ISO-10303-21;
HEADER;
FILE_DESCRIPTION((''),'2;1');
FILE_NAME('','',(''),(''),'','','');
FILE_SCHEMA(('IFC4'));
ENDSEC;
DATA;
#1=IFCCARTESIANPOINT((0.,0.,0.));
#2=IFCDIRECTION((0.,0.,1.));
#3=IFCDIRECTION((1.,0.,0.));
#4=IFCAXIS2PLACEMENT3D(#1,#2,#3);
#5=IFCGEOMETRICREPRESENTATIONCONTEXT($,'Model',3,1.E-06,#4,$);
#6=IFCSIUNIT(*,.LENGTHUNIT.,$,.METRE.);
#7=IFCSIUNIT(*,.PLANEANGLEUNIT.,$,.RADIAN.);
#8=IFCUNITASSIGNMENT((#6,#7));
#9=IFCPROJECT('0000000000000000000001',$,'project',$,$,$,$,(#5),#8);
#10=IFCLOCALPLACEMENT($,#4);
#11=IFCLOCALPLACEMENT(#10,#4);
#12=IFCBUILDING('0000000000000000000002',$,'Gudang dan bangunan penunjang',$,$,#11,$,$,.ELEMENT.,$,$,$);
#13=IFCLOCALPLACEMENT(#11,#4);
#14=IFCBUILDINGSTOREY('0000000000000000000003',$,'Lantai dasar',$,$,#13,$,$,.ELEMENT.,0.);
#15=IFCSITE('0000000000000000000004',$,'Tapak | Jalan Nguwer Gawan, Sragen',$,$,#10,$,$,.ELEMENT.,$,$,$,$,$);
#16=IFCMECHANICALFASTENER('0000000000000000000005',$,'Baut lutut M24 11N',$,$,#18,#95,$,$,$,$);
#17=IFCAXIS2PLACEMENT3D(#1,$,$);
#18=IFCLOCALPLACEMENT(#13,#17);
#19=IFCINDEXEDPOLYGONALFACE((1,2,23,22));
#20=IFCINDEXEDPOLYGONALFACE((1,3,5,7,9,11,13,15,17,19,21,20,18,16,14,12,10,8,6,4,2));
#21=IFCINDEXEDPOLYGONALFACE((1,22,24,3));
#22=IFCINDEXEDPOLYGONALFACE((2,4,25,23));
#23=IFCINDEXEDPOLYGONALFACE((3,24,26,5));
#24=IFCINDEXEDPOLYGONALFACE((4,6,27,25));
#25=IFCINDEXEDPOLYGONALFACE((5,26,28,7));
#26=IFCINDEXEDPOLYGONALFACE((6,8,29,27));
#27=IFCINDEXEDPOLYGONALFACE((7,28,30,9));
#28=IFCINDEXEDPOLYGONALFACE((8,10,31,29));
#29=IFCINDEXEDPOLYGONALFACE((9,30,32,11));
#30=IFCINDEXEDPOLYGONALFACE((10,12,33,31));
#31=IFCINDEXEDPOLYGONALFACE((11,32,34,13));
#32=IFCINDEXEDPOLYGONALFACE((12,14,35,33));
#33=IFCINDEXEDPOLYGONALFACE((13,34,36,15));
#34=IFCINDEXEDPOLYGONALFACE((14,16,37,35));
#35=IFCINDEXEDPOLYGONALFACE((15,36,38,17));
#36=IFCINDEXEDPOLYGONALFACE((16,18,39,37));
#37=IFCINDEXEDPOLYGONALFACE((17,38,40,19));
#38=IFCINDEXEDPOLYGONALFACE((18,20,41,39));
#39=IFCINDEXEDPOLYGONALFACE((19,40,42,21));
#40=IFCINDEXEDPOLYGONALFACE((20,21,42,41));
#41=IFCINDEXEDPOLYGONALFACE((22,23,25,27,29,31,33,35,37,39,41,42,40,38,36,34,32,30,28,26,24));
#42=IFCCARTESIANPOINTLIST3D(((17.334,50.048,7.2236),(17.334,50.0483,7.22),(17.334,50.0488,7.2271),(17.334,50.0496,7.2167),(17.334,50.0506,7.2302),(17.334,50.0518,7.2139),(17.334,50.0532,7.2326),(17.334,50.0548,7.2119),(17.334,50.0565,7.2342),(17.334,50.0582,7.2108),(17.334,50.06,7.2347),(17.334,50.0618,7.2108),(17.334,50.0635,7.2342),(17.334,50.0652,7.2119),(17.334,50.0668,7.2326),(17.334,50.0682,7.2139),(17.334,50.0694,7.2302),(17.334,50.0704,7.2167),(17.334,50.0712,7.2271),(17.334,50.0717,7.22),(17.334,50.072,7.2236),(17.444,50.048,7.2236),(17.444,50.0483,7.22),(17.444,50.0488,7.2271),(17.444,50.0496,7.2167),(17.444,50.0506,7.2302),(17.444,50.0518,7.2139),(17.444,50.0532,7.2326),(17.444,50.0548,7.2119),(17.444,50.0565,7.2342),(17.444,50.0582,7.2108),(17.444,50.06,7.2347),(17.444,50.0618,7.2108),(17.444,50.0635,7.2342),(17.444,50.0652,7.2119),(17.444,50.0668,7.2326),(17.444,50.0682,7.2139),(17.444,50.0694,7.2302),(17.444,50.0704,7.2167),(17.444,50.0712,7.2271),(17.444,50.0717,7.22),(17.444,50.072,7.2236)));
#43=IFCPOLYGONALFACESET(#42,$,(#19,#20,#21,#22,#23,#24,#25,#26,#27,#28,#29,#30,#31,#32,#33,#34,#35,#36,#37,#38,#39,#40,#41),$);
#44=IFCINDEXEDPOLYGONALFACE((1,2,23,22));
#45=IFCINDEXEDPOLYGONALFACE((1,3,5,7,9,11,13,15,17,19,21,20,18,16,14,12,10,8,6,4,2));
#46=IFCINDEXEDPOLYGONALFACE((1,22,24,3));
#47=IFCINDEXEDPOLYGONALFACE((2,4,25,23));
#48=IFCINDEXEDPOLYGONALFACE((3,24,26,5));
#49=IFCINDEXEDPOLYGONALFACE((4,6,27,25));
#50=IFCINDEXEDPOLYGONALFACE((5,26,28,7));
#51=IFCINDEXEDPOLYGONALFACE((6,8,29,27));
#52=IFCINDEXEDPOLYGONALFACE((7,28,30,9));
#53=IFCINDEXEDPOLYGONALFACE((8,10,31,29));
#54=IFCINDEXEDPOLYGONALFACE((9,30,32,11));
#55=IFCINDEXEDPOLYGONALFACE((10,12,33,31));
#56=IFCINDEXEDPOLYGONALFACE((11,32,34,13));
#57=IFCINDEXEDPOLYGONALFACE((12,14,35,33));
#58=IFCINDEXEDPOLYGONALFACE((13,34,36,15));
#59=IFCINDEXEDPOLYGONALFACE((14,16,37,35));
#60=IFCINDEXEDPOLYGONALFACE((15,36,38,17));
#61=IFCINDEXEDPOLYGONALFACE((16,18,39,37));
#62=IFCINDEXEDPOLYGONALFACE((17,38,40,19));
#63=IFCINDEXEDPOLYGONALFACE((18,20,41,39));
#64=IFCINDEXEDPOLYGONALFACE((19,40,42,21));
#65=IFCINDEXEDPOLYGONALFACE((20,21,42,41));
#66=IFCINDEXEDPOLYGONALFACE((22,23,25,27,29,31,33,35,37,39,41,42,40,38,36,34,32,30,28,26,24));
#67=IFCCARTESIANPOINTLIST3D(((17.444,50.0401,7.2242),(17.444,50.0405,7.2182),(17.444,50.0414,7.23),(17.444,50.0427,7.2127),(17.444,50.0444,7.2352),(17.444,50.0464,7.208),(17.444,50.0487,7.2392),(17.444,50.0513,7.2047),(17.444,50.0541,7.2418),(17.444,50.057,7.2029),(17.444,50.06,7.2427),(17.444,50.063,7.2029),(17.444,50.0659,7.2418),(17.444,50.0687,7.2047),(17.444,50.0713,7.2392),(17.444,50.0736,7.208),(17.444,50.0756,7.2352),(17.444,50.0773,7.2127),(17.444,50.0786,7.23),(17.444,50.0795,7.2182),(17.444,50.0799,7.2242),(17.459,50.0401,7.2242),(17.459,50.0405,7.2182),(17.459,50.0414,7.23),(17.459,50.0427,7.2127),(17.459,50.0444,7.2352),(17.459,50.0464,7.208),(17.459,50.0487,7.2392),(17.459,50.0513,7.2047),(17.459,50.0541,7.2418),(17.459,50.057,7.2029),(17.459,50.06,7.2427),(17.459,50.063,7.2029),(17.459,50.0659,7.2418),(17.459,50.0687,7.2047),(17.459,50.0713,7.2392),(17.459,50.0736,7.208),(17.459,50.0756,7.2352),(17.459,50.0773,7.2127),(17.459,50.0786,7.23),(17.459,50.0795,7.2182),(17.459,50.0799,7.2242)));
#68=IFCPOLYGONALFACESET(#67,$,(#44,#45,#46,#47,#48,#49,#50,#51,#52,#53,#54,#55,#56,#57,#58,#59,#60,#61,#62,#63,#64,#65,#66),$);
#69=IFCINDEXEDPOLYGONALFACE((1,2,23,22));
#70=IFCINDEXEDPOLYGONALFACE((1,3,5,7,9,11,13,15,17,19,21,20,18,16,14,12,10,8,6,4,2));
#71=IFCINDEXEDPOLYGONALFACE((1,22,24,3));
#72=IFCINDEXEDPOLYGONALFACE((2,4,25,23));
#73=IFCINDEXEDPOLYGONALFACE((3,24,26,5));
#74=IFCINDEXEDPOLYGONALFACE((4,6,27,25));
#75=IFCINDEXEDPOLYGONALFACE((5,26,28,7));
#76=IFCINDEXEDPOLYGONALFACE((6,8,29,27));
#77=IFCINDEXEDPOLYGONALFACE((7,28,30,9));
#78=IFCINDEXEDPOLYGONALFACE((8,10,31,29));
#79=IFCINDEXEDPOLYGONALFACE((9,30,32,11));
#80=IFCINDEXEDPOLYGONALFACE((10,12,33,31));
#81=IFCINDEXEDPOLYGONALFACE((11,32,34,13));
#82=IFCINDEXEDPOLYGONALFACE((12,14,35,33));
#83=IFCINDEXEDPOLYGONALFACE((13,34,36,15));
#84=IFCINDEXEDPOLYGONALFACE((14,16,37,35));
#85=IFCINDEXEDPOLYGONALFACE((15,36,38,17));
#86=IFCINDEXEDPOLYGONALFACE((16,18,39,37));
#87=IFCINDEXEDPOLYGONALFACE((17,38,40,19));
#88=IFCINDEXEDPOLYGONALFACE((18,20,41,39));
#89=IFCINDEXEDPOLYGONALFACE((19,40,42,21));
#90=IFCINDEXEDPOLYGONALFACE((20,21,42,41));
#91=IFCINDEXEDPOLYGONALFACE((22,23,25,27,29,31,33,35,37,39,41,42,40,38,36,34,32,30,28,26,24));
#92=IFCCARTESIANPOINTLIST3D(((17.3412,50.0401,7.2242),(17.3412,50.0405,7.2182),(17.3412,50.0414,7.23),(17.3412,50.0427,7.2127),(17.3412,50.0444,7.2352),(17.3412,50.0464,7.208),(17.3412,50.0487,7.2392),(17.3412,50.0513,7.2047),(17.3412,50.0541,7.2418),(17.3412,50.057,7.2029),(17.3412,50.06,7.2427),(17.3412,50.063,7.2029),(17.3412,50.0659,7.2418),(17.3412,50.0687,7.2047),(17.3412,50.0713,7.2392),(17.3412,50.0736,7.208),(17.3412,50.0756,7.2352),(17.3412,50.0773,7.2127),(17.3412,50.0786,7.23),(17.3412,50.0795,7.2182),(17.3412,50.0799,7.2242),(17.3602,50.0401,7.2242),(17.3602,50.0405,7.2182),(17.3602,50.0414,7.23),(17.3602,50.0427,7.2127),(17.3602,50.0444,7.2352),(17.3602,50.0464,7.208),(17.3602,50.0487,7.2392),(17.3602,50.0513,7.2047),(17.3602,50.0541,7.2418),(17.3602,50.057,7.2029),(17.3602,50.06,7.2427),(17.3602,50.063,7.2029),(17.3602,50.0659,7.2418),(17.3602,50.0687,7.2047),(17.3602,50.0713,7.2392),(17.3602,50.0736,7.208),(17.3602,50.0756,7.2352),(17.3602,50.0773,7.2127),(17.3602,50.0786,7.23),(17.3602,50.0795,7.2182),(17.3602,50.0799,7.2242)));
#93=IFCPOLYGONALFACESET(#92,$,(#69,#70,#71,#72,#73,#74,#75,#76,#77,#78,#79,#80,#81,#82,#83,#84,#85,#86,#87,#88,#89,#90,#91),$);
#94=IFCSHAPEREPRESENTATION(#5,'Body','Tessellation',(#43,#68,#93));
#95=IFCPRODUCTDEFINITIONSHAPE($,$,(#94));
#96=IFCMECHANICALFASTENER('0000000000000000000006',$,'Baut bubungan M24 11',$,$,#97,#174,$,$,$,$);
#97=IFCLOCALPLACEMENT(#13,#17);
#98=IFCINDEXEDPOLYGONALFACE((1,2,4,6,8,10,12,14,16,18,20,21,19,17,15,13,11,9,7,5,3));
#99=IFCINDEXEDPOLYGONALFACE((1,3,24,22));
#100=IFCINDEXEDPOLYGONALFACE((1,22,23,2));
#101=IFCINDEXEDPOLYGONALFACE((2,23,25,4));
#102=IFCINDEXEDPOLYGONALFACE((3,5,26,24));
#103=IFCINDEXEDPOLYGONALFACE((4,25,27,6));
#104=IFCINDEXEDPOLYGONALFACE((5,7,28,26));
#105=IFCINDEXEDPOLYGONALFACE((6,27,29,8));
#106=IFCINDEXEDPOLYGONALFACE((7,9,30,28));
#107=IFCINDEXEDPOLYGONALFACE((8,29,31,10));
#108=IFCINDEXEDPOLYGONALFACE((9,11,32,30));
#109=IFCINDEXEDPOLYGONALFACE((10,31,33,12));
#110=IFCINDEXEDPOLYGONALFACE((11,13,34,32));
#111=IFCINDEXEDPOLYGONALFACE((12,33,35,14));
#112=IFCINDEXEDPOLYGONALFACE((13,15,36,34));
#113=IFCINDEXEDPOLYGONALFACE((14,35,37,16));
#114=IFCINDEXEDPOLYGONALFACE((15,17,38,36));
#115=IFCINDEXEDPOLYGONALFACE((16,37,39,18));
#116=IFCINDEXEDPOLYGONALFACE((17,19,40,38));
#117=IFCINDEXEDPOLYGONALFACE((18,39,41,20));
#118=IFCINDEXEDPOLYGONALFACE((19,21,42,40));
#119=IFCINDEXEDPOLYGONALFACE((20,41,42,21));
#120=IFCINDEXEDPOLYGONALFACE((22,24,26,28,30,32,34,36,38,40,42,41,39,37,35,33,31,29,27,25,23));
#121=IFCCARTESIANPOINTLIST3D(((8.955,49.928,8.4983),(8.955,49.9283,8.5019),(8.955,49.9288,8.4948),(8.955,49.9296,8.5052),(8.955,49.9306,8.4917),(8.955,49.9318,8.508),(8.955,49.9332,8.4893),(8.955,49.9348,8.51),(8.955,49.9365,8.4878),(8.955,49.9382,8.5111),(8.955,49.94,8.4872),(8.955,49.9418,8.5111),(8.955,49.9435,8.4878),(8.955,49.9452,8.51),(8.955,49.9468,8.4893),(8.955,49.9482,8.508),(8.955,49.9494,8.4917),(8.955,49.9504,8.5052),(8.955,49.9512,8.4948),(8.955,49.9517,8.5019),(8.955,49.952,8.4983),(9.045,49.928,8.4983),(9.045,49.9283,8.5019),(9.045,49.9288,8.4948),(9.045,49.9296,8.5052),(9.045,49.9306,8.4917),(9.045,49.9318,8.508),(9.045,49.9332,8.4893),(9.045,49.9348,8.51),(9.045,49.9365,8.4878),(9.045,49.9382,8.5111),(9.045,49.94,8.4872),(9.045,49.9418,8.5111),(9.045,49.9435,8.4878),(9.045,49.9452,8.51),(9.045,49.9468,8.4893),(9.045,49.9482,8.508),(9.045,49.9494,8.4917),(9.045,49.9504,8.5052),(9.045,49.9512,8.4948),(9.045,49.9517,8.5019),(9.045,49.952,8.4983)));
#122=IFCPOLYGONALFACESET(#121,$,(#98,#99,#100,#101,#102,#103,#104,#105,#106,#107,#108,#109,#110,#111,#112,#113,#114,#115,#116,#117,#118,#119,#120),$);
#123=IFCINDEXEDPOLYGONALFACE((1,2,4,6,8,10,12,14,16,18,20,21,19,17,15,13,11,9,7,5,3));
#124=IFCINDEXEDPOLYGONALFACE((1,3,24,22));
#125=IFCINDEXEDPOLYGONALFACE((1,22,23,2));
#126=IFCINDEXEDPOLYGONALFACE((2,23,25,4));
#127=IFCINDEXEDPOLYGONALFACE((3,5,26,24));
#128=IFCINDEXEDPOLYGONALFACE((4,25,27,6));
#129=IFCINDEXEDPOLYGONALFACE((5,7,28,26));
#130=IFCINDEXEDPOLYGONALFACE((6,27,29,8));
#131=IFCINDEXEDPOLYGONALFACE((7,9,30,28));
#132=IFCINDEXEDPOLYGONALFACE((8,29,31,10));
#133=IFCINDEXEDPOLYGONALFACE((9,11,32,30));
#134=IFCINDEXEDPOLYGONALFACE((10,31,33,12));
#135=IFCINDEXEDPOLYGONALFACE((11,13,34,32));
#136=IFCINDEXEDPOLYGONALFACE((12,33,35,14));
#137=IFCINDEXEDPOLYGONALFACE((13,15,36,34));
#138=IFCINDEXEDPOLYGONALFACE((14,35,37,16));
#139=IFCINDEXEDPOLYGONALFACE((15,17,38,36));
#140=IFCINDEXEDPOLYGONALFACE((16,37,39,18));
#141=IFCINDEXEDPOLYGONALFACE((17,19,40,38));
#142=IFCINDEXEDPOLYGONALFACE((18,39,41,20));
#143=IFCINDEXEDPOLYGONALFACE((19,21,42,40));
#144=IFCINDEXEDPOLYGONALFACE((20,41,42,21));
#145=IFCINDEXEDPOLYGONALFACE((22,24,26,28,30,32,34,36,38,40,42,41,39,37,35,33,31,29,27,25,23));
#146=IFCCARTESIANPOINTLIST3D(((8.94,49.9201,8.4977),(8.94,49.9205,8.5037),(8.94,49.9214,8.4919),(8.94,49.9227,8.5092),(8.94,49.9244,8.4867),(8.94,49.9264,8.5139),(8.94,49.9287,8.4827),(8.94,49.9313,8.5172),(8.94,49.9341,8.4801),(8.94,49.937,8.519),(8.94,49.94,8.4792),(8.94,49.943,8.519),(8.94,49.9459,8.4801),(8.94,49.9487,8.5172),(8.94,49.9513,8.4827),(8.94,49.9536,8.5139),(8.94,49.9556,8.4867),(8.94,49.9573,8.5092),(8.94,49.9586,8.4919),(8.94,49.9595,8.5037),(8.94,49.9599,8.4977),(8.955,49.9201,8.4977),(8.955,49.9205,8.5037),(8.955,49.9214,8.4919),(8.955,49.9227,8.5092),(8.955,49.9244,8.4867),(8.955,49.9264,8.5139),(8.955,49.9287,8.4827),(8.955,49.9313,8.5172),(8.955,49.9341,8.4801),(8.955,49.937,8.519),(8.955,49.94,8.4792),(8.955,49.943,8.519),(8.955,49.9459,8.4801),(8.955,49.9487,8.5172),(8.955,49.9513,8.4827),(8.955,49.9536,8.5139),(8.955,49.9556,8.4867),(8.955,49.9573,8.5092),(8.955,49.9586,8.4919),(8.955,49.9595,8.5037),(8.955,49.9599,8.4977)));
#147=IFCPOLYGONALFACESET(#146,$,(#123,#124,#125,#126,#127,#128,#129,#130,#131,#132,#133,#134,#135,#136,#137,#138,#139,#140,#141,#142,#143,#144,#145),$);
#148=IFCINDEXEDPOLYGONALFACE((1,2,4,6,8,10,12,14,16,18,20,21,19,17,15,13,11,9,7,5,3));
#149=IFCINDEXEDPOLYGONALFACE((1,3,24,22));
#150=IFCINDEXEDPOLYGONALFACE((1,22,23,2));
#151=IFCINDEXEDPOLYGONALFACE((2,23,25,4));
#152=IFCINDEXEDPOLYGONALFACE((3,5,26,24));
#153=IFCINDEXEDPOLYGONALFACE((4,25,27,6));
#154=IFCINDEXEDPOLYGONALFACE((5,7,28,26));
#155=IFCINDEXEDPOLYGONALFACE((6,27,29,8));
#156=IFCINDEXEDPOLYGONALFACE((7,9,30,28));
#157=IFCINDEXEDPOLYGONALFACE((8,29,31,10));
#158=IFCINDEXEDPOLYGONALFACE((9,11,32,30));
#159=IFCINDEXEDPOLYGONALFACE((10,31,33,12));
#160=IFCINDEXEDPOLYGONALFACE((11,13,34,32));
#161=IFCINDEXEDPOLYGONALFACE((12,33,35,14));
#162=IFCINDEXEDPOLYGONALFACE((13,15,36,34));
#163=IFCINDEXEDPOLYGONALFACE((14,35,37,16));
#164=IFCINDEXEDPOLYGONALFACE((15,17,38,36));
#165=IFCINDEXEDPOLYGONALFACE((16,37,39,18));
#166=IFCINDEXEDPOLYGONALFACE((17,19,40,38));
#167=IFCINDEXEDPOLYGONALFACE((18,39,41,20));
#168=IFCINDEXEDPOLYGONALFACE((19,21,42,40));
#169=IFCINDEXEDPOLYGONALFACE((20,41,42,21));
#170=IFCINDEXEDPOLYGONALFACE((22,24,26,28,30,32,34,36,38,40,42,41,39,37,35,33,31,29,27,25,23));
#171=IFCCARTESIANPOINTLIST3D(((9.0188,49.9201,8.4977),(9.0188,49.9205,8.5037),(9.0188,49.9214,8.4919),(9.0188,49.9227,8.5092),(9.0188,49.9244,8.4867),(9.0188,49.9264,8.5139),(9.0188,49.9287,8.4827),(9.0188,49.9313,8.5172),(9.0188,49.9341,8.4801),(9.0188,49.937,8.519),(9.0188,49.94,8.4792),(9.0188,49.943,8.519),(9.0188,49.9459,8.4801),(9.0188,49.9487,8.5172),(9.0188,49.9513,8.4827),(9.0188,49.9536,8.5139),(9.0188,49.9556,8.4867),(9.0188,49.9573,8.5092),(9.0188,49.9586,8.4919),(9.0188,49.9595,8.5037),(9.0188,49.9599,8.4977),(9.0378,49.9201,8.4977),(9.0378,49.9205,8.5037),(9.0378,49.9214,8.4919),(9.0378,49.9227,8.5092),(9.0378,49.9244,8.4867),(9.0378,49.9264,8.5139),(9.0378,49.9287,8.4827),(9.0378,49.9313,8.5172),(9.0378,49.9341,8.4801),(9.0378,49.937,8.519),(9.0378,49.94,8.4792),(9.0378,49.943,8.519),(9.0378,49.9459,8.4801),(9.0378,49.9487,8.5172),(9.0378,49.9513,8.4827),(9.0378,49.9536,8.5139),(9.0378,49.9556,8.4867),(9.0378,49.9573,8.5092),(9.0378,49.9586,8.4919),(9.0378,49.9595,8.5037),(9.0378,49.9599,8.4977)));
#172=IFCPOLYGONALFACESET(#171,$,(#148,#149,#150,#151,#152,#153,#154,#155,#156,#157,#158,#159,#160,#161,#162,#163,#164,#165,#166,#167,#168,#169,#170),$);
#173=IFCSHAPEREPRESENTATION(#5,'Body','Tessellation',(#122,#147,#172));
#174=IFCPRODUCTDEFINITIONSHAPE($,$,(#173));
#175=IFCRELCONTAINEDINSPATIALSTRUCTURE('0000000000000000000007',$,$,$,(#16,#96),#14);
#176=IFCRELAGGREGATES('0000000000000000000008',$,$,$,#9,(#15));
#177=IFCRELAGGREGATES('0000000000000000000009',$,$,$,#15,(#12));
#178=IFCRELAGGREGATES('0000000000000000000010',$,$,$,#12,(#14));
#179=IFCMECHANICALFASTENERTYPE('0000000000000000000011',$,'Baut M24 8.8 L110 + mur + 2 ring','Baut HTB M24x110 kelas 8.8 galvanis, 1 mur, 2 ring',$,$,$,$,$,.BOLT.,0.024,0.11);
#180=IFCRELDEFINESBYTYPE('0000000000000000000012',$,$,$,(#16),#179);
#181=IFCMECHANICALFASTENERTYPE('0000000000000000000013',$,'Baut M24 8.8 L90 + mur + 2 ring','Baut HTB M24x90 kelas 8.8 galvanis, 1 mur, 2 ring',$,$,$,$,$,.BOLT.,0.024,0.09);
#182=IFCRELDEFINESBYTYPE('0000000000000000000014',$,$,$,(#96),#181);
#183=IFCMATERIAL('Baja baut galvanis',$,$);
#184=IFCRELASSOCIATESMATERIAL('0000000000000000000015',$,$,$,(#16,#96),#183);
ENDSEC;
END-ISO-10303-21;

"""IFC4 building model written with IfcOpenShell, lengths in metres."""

from ifc_helpers import new_model, si_unit, frame, origin_with_axes, place, context, project, spatial, circle, extrude, source, transform, mapped, material, type_object, type_shapes, element, save


model = new_model("IFC4")

# Units and contexts
model_context = context("Model", 3, precision=1e-06, world=origin_with_axes())
ifc_project = project(units=[si_unit("LENGTHUNIT", "METRE"), si_unit("PLANEANGLEUNIT", "RADIAN")], contexts=[model_context])

# Site, building, storey
site_placement = place(None, origin_with_axes())
site = spatial("IfcSite", under=ifc_project, at=site_placement, Name="Tapak | Jalan Nguwer Gawan, Sragen", CompositionType="ELEMENT")
building_placement = place(site_placement, origin_with_axes())
building = spatial("IfcBuilding", under=site, at=building_placement, Name="Gudang dan bangunan penunjang", CompositionType="ELEMENT")
storey_placement = place(building_placement, origin_with_axes())
storey = spatial("IfcBuildingStorey", under=building, at=storey_placement, Name="Lantai dasar", CompositionType="ELEMENT", Elevation=0.0)

# Shared definitions
placement = place(None, origin_with_axes())

# Mechanical fasteners
ifc_material_1 = material(Name="Baja baut galvanis")
mechanical_fastener_type_1 = type_object("IfcMechanicalFastenerType", Name="Baut M24 8.8 L110 + mur + 2 ring", Description="Baut HTB M24x110 kelas 8.8 galvanis, 1 mur, 2 ring", NominalDiameter=0.024, NominalLength=0.11, PredefinedType="BOLT")
shared_shape_1 = source(origin_with_axes(), model_context, "Body", "SweptSolid", [
    extrude(circle(Radius=0.012), origin_with_axes(), (0.0, 0.0, 1.0), 0.11),
    extrude(circle(Radius=0.02), frame((0.0, 0.0, -0.015), z_axis=(0.0, 0.0, 1.0), x_axis=(1.0, 0.0, 0.0)), (0.0, 0.0, 1.0), 0.015),
    extrude(circle(Radius=0.02), frame((0.0, 0.0, 0.0838), z_axis=(0.0, 0.0, 1.0), x_axis=(1.0, 0.0, 0.0)), (0.0, 0.0, 1.0), 0.019),
])
type_shapes(mechanical_fastener_type_1, [shared_shape_1])
element("IfcMechanicalFastener", 1, at=placement, inside=storey, type_object=mechanical_fastener_type_1, material=ifc_material_1, Name="Baut lutut M24 11N", context=model_context, shape_type="MappedRepresentation", body=[
    mapped(shared_shape_1, transform((17.444, 50.06, 7.2227), x_axis=(0.0, 0.0, 1.0), y_axis=(0.0, 1.0, 0.0), z_axis=(-1.0, 0.0, 0.0), scale=1.0)),
])
mechanical_fastener_type_2 = type_object("IfcMechanicalFastenerType", Name="Baut M24 8.8 L90 + mur + 2 ring", Description="Baut HTB M24x90 kelas 8.8 galvanis, 1 mur, 2 ring", NominalDiameter=0.024, NominalLength=0.09, PredefinedType="BOLT")
shared_shape_2 = source(origin_with_axes(), model_context, "Body", "SweptSolid", [
    extrude(circle(Radius=0.012), origin_with_axes(), (0.0, 0.0, 1.0), 0.09),
    extrude(circle(Radius=0.02), frame((0.0, 0.0, -0.015), z_axis=(0.0, 0.0, 1.0), x_axis=(1.0, 0.0, 0.0)), (0.0, 0.0, 1.0), 0.015),
    extrude(circle(Radius=0.02), frame((0.0, 0.0, 0.0638), z_axis=(0.0, 0.0, 1.0), x_axis=(1.0, 0.0, 0.0)), (0.0, 0.0, 1.0), 0.019),
])
type_shapes(mechanical_fastener_type_2, [shared_shape_2])
element("IfcMechanicalFastener", 2, at=placement, inside=storey, type_object=mechanical_fastener_type_2, material=ifc_material_1, Name="Baut bubungan M24 11", context=model_context, shape_type="MappedRepresentation", body=[
    mapped(shared_shape_2, transform((8.955, 49.94, 8.4992), x_axis=(0.0, 0.0, -1.0), y_axis=(0.0, 1.0, 0.0), z_axis=(1.0, 0.0, 0.0), scale=1.0)),
])

save(model, "model.ifc")
